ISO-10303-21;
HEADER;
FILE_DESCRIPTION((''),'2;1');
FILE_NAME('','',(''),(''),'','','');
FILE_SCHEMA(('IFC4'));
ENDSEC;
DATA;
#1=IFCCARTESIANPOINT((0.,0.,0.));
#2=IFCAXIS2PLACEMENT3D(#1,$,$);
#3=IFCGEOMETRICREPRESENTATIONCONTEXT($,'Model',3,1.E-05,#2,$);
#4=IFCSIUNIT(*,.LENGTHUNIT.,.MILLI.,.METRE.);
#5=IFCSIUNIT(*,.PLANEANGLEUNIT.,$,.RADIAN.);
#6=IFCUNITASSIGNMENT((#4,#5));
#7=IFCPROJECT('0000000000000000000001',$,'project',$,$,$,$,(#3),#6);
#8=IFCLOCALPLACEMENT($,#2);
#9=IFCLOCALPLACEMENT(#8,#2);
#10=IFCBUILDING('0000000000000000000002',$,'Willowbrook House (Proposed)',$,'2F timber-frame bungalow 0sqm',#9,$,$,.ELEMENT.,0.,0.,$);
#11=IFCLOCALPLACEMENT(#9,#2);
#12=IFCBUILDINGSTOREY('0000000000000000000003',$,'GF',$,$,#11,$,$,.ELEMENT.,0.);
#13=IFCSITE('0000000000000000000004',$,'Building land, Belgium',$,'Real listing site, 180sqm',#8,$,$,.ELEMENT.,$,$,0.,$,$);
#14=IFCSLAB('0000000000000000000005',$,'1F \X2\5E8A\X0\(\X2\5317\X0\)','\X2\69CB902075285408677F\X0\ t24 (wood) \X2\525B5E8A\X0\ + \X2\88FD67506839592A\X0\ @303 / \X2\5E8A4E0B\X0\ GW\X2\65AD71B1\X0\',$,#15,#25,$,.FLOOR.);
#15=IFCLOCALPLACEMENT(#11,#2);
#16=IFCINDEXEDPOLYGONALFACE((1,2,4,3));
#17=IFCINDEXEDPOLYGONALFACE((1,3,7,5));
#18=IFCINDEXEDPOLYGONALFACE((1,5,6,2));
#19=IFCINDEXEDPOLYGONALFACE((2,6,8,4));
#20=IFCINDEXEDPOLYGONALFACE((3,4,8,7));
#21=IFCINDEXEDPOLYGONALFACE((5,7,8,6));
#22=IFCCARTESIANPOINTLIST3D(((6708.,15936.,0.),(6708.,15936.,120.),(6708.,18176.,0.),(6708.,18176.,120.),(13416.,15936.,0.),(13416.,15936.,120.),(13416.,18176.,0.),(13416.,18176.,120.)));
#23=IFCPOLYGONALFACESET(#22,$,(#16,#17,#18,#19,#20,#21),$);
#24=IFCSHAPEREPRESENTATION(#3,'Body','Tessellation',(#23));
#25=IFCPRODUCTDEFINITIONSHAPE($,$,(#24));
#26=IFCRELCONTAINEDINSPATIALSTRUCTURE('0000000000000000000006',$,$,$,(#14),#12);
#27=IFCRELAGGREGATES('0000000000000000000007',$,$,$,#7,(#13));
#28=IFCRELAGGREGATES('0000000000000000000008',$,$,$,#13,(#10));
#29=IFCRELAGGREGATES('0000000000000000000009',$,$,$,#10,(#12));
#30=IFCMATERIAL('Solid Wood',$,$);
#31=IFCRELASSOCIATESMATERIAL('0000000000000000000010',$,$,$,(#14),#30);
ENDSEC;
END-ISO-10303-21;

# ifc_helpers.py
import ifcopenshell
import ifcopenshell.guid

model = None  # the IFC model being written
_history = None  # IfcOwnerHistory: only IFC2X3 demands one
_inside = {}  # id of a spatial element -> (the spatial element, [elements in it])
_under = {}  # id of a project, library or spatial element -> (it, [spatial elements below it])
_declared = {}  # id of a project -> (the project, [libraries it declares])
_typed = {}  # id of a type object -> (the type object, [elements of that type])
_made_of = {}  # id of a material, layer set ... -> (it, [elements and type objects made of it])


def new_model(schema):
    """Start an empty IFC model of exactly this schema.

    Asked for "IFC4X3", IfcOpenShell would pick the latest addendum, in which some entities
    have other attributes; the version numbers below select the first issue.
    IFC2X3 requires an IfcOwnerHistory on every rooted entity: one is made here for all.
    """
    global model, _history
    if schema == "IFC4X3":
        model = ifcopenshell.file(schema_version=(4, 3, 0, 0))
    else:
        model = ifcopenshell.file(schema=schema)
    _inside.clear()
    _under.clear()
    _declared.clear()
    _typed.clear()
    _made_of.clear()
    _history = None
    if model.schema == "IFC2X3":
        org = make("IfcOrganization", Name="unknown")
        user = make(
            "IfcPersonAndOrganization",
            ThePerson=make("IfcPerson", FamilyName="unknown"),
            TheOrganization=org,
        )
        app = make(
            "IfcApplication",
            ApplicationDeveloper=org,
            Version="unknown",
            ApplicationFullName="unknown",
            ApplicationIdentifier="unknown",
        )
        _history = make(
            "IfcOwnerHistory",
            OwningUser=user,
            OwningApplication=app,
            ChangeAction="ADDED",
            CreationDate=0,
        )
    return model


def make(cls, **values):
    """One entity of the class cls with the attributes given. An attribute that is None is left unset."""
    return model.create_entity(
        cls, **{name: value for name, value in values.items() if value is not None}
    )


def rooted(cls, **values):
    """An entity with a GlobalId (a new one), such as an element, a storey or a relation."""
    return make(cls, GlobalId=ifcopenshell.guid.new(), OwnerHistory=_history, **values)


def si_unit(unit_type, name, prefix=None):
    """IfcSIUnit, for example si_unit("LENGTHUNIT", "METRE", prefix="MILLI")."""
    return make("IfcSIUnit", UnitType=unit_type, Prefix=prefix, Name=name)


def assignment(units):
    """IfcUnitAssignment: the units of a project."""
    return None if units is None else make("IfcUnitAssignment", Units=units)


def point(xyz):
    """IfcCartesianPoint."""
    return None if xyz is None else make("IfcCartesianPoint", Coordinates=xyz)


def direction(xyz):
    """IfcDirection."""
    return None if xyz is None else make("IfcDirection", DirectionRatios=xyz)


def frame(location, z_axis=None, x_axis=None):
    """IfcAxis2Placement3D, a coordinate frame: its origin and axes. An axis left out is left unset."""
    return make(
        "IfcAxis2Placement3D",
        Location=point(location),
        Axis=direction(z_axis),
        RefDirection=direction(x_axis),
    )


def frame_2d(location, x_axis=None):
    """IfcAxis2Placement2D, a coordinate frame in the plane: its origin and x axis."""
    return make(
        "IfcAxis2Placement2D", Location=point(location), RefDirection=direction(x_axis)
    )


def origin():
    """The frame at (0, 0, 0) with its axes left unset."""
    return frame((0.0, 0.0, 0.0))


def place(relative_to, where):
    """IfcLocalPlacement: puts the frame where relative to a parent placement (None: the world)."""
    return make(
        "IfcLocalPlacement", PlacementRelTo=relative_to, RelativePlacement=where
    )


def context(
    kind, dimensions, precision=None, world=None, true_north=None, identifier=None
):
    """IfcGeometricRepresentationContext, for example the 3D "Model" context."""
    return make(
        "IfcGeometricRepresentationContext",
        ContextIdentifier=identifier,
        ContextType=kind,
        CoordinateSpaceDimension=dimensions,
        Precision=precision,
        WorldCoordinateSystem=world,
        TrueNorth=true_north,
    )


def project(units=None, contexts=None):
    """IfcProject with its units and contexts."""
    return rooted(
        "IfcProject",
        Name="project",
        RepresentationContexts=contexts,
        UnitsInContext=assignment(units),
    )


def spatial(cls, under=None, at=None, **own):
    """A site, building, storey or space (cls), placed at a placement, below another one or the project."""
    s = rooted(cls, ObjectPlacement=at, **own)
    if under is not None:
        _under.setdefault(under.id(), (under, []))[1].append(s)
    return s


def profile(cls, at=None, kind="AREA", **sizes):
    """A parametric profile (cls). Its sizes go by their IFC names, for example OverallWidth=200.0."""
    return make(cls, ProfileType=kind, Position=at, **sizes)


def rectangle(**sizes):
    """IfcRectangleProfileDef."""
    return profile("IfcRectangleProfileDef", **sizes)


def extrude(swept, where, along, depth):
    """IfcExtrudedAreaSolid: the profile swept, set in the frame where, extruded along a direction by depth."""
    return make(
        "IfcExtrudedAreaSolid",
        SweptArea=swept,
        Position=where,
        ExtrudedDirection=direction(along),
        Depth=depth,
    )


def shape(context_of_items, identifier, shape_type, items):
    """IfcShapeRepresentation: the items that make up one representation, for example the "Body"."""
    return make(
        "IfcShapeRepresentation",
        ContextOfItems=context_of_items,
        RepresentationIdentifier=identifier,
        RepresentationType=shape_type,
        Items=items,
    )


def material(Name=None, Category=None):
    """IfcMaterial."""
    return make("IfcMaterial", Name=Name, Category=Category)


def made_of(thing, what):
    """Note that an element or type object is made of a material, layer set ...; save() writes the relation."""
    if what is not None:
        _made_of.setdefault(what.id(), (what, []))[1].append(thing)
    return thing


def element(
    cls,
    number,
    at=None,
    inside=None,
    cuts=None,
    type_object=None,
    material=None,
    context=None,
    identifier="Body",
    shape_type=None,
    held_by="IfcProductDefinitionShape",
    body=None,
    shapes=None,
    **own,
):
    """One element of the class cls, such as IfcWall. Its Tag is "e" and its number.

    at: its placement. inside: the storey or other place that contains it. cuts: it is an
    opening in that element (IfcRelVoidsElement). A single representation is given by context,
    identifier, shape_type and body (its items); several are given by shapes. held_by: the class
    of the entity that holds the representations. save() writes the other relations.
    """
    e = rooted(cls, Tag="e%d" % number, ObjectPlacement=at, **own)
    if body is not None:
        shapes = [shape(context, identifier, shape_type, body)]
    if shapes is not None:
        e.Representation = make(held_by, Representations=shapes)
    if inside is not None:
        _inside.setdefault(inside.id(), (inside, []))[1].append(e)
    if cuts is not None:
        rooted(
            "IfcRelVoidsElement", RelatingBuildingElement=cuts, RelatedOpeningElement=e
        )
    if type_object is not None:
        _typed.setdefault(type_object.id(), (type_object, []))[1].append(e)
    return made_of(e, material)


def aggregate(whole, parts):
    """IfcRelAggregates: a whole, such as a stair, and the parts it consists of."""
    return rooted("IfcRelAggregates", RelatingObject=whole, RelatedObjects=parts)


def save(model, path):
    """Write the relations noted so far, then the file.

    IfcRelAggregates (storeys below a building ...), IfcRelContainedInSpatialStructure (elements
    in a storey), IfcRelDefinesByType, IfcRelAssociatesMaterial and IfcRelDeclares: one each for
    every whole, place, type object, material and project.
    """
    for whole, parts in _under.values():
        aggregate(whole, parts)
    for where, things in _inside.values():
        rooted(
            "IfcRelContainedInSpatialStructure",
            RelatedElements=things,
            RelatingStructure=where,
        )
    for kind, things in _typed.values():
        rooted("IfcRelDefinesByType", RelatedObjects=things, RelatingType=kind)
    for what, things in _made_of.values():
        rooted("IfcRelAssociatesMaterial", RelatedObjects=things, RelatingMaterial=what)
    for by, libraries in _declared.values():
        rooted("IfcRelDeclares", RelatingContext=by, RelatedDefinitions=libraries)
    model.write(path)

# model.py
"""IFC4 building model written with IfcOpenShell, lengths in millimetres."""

from ifc_helpers import new_model, si_unit, frame, frame_2d, origin, place, context, project, spatial, rectangle, extrude, material, element, save


model = new_model("IFC4")

# Units and contexts
model_context = context("Model", 3, precision=1e-05, world=origin())
ifc_project = project(units=[si_unit("LENGTHUNIT", "METRE", prefix="MILLI"), si_unit("PLANEANGLEUNIT", "RADIAN")], contexts=[model_context])

# Site, building, storey
site_placement = place(None, origin())
site = spatial("IfcSite", under=ifc_project, at=site_placement, Name="Building land, Belgium", ObjectType="Real listing site, 180sqm", CompositionType="ELEMENT", RefElevation=0.0)
building_placement = place(site_placement, origin())
building = spatial("IfcBuilding", under=site, at=building_placement, Name="Willowbrook House (Proposed)", ObjectType="2F timber-frame bungalow 0sqm", CompositionType="ELEMENT", ElevationOfRefHeight=0.0, ElevationOfTerrain=0.0)
storey_placement = place(building_placement, origin())
storey = spatial("IfcBuildingStorey", under=building, at=storey_placement, Name="GF", CompositionType="ELEMENT", Elevation=0.0)

# Slab
ifc_material_1 = material(Name="Solid Wood")
slab_1_placement = place(storey_placement, frame((3354.0, 7968.0, 0.0)))
element("IfcSlab", 1, at=slab_1_placement, inside=storey, material=ifc_material_1, Name="1F 床(北)", Description="構造用合板 t24 (wood) 剛床 + 製材根太 @303 / 床下 GW断熱", PredefinedType="FLOOR", context=model_context, shape_type="SweptSolid", body=[
    extrude(rectangle(XDim=6708.0, YDim=2240.0, at=frame_2d((3354.0, 1120.0))), frame((3354.0, 7968.0, 0.0)), (0.0, 0.0, 1.0), 120.0),
])

save(model, "model.ifc")
